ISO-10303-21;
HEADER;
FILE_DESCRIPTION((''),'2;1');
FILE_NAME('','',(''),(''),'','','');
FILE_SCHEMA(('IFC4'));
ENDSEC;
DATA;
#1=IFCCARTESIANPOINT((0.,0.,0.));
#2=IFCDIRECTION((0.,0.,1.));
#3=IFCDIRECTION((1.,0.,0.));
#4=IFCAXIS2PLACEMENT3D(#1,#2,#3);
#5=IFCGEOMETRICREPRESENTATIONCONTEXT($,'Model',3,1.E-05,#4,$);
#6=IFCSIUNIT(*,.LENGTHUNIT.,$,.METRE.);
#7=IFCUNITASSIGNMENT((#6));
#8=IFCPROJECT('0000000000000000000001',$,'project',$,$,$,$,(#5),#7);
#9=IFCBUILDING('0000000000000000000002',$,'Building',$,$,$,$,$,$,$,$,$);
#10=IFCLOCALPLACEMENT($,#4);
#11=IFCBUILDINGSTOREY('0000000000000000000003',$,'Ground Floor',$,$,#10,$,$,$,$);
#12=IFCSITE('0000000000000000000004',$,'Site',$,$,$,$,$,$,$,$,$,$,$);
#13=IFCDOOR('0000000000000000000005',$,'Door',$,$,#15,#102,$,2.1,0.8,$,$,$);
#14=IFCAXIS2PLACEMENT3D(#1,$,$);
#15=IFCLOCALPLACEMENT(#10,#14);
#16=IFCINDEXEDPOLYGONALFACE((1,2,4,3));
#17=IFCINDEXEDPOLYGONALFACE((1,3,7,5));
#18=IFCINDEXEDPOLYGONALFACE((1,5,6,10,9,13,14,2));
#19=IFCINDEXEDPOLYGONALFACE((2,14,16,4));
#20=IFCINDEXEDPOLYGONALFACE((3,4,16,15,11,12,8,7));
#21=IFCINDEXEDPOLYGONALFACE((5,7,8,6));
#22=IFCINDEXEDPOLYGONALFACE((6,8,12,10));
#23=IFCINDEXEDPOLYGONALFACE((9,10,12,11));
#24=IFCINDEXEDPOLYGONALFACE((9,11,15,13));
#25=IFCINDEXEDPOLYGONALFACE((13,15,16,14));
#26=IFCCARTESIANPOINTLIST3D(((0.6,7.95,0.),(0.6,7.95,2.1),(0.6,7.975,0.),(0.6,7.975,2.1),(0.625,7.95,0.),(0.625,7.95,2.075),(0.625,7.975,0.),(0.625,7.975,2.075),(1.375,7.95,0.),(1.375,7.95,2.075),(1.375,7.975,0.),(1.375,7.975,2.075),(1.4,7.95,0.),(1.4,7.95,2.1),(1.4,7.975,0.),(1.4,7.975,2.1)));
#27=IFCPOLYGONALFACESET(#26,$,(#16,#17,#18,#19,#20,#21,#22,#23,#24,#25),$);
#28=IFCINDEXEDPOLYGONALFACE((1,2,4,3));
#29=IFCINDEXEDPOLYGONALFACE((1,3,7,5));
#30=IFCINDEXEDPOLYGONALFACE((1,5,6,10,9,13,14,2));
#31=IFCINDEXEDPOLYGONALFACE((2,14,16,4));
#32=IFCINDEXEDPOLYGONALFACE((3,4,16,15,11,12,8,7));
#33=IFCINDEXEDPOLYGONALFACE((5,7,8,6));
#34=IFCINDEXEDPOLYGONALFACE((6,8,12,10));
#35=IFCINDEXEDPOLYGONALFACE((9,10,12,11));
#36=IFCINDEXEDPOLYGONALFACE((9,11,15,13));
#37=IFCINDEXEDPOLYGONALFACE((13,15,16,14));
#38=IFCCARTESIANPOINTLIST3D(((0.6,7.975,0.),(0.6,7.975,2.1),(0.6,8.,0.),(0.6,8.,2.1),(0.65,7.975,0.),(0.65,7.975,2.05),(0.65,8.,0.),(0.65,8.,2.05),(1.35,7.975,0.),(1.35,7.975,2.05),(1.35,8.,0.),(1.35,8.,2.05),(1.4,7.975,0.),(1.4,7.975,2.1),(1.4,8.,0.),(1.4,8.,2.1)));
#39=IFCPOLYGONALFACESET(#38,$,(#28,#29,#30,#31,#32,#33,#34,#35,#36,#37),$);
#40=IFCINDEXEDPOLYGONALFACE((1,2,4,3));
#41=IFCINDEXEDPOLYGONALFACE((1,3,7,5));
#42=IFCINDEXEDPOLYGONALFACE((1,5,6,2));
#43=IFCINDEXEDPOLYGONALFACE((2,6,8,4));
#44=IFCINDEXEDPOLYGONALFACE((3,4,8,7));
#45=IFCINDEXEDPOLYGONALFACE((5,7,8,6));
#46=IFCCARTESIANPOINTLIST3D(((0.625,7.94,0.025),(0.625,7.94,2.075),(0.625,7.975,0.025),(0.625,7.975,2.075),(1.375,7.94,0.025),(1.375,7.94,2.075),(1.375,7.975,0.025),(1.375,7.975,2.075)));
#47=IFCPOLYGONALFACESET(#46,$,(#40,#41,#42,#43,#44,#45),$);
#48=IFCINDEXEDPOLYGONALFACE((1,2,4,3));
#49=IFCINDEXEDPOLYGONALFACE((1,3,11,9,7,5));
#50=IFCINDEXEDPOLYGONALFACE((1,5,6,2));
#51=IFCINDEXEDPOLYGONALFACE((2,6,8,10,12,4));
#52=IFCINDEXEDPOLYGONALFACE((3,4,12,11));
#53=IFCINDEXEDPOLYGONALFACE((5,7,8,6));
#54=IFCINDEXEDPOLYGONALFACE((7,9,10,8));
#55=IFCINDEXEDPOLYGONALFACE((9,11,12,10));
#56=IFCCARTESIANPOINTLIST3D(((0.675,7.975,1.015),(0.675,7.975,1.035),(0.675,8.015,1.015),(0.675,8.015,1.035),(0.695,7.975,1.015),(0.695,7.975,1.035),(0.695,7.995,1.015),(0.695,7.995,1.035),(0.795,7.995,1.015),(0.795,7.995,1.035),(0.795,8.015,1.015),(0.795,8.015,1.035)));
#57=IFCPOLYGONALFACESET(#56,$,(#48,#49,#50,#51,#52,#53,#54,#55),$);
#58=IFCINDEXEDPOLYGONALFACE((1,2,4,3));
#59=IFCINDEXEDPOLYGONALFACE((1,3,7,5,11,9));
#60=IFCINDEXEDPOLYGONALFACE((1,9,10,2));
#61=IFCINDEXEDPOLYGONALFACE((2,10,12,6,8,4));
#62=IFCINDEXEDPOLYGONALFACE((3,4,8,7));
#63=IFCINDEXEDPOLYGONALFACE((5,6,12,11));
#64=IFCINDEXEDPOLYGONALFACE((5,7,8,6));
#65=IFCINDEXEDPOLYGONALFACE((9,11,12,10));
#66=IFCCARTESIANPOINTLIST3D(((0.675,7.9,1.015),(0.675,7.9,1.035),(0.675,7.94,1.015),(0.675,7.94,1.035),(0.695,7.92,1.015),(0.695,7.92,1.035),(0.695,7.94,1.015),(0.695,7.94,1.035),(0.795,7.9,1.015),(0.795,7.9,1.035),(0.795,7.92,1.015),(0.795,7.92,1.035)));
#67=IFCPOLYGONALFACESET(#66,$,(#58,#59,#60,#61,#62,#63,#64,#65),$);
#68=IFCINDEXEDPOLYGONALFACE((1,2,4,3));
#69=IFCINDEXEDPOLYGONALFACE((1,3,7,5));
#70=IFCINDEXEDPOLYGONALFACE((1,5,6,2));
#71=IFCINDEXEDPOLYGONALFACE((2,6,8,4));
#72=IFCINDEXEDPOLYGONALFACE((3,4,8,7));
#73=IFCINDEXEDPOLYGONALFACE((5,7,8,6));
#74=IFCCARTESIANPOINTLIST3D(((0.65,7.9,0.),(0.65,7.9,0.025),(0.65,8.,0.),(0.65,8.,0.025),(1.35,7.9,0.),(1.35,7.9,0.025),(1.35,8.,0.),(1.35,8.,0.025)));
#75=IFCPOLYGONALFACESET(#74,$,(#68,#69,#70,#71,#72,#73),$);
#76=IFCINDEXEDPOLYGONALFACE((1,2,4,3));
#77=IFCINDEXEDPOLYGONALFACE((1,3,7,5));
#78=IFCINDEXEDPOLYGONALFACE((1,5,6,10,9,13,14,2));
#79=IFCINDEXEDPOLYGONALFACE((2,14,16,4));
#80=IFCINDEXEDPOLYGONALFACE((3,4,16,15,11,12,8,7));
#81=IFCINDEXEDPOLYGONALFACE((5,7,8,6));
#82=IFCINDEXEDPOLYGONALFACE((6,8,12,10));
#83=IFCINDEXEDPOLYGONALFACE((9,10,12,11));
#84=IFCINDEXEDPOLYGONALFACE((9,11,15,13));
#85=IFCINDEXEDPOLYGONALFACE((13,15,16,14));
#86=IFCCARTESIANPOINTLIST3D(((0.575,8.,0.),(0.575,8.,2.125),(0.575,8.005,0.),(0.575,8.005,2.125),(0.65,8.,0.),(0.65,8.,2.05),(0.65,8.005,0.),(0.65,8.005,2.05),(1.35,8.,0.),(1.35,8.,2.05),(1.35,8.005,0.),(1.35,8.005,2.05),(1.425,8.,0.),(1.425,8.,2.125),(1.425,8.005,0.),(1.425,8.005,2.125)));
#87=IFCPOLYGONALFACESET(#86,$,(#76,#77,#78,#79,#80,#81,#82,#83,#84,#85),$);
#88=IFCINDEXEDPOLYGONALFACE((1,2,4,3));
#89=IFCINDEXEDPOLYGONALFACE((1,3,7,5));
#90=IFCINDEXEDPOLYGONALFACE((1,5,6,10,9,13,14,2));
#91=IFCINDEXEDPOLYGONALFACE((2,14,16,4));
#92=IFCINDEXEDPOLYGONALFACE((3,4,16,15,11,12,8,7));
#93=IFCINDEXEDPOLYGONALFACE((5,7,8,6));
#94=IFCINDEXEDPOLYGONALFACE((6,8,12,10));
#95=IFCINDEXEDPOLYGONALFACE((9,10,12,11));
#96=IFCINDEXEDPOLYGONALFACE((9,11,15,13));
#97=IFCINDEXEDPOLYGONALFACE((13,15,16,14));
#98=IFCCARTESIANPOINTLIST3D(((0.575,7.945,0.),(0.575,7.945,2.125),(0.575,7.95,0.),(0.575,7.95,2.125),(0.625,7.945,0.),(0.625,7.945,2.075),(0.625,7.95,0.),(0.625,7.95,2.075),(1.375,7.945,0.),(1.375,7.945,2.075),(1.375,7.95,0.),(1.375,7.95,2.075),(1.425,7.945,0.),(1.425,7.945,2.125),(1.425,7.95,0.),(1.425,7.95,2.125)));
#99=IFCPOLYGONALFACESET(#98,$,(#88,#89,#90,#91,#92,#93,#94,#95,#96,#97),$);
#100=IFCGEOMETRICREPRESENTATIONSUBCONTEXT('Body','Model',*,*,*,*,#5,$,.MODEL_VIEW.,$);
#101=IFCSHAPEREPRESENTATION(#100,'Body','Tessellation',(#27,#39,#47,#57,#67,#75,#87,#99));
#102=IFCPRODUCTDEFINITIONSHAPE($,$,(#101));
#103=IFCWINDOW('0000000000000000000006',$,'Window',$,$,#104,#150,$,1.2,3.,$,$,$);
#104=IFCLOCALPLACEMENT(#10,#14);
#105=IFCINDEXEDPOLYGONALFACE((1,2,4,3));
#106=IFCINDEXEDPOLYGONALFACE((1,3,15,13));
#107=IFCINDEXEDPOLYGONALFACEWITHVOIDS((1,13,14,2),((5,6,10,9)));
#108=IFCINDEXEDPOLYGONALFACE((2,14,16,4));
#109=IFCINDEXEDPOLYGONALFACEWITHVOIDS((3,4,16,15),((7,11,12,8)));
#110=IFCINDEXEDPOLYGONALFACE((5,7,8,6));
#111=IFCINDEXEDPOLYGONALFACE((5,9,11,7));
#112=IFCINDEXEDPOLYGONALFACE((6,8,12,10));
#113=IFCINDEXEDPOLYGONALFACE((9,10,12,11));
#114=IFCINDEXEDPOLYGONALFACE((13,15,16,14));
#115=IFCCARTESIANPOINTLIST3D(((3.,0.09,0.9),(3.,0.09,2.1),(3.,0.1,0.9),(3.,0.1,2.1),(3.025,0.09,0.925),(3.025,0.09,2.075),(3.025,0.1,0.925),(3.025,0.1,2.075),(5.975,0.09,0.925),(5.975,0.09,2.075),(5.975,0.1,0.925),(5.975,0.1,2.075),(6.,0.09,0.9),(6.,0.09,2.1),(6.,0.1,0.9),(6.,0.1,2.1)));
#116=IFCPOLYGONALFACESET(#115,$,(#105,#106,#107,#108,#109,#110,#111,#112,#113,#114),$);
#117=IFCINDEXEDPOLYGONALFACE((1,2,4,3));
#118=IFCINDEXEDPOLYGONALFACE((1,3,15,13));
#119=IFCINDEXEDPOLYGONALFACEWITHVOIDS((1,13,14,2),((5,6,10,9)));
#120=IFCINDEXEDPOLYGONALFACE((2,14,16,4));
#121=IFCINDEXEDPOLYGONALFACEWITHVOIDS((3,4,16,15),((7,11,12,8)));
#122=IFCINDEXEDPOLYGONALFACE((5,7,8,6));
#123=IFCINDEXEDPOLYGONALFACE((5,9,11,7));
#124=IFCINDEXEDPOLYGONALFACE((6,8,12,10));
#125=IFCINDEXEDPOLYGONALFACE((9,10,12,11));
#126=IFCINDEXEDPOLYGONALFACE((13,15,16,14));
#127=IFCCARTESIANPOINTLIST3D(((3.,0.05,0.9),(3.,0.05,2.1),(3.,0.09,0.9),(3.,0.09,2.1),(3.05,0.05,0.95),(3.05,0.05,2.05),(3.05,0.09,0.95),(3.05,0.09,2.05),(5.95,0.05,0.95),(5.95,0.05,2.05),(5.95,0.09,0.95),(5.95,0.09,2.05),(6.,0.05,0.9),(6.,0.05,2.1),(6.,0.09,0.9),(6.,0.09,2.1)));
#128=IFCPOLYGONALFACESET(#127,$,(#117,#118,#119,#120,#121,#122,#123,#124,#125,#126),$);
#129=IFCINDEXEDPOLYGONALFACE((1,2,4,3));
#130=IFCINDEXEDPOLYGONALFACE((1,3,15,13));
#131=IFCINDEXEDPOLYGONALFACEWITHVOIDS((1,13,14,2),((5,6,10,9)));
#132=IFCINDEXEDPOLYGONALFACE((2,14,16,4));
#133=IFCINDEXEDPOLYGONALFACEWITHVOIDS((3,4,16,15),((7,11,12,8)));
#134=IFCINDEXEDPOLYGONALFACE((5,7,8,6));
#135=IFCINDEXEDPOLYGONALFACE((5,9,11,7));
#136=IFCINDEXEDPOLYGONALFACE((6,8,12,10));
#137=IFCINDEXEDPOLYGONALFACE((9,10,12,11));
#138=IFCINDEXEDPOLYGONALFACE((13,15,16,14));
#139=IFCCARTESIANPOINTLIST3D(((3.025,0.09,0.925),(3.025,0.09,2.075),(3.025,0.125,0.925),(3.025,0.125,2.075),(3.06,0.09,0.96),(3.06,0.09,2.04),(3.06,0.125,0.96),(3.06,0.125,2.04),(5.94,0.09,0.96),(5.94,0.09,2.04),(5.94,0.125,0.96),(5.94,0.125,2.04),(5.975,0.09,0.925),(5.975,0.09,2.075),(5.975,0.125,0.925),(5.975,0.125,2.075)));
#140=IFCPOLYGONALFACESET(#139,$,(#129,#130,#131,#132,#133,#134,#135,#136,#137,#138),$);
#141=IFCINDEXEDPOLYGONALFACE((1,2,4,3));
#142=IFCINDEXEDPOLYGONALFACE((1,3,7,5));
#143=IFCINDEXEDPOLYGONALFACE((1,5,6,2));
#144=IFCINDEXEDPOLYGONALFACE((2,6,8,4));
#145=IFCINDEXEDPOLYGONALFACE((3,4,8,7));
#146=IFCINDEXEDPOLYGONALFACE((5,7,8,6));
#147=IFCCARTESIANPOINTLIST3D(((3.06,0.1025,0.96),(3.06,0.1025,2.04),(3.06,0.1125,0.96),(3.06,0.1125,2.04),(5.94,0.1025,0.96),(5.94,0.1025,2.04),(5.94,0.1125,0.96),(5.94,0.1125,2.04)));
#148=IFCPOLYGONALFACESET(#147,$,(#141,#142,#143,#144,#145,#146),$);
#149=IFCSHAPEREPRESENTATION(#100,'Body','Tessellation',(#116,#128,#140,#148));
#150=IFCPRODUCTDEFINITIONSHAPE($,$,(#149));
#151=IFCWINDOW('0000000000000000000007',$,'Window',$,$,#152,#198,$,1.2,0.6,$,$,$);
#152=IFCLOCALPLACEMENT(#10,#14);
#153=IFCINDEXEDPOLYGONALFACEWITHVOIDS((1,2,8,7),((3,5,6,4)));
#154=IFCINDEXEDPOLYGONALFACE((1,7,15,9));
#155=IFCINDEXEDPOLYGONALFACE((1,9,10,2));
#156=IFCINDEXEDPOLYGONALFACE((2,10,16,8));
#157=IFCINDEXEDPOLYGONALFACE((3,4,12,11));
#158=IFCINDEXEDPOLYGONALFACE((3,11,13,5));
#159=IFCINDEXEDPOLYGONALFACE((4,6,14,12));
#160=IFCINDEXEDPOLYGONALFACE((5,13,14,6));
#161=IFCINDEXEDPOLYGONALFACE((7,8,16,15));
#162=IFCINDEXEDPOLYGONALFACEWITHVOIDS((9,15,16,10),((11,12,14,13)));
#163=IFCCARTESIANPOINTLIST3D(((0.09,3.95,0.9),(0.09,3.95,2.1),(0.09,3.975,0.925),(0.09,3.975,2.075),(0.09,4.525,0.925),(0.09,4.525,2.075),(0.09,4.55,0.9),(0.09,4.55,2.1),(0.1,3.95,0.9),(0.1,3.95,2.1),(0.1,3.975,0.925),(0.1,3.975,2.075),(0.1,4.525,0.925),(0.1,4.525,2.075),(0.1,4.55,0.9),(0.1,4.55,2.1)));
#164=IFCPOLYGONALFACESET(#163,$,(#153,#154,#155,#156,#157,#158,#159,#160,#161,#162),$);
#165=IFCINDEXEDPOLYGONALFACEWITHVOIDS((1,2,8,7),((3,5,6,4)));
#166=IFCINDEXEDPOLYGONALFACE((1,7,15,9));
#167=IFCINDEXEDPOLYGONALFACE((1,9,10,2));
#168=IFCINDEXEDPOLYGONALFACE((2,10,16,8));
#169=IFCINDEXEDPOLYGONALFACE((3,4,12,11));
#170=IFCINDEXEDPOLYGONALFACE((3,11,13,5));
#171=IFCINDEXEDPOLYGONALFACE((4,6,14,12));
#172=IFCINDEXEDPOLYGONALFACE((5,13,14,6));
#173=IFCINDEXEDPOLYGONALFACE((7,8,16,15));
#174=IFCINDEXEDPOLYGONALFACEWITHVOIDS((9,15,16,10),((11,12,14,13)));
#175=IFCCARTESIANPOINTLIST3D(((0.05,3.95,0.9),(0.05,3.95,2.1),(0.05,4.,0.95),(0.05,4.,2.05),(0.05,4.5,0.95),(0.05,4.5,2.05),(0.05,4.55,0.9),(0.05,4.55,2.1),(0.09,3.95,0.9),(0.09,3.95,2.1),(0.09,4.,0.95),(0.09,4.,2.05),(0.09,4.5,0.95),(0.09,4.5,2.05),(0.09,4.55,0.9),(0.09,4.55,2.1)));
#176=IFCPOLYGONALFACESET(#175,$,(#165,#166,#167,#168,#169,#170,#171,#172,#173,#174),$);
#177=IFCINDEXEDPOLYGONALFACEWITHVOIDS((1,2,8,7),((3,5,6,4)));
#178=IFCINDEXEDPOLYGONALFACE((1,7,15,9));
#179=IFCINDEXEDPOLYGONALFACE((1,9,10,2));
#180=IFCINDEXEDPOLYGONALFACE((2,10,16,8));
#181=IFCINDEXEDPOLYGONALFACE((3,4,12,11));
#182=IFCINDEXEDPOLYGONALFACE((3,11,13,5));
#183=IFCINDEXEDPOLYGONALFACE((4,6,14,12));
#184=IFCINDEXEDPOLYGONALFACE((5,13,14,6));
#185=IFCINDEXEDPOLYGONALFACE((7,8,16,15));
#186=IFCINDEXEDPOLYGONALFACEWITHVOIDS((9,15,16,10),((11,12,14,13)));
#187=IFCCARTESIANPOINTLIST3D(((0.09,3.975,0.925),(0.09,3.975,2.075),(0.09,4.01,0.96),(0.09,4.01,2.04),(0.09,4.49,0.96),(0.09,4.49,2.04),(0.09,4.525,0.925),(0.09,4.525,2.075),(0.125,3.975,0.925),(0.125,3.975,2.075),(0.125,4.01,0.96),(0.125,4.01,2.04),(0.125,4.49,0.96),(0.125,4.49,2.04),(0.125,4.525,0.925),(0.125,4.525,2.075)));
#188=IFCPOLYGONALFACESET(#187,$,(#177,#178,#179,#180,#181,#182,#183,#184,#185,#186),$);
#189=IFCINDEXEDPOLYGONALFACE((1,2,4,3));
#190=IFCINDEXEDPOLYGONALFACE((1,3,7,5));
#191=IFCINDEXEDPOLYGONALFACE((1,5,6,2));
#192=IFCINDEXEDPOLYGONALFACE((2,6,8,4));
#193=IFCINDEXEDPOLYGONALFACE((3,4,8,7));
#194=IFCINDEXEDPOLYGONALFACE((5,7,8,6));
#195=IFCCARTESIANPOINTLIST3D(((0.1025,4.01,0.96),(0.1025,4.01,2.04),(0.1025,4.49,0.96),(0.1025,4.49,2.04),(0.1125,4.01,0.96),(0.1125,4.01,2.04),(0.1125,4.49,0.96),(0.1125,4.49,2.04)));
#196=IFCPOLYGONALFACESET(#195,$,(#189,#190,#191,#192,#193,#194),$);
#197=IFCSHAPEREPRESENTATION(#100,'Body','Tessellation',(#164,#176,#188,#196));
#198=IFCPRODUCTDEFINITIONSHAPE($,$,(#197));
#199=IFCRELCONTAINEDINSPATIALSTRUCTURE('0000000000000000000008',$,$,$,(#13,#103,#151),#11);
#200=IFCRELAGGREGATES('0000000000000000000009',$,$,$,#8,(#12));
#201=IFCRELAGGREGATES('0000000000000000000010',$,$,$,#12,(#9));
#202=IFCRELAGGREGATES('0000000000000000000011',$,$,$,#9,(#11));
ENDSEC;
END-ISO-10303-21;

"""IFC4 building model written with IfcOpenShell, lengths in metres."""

from ifc_helpers import new_model, si_unit, frame, origin_with_axes, place, context, subcontext, project, spatial, line, indexed_curve, outline, extrude, element, save


model = new_model("IFC4")

# Units and contexts
model_context = context("Model", 3, precision=1e-05, world=origin_with_axes())
body_context = subcontext(model_context, "Body", "Model", "MODEL_VIEW")
ifc_project = project(units=[si_unit("LENGTHUNIT", "METRE")], contexts=[model_context])

# Site, building, storey
site = spatial("IfcSite", under=ifc_project, Name="Site")
building = spatial("IfcBuilding", under=site, Name="Building")
storey_placement = place(None, origin_with_axes())
storey = spatial("IfcBuildingStorey", under=building, at=storey_placement, Name="Ground Floor")

# Door
door_1_placement = place(storey_placement, frame((1.4, 8.0, 0.0), z_axis=(0.0, 0.0, 1.0), x_axis=(-1.0, 0.0, 0.0)))
element("IfcDoor", 1, at=door_1_placement, inside=storey, Name="Door", OverallHeight=2.1, OverallWidth=0.8, context=body_context, shape_type="SweptSolid", body=[
    extrude(outline(indexed_curve([(0.0, 0.0), (0.0, 2.1), (0.8, 2.1), (0.8, 0.0), (0.775, 0.0), (0.775, 2.075), (0.025, 2.075), (0.025, 0.0)], segments=[line(1, 2, 3, 4, 5, 6, 7, 8, 1)])), frame((0.0, 0.025, 0.0), z_axis=(0.0, -1.0, 0.0), x_axis=(1.0, 0.0, 0.0)), (0.0, 0.0, -1.0), 0.025),
    extrude(outline(indexed_curve([(0.0, 0.0), (0.0, 2.1), (0.8, 2.1), (0.8, 0.0), (0.75, 0.0), (0.75, 2.05), (0.05, 2.05), (0.05, 0.0)], segments=[line(1, 2, 3, 4, 5, 6, 7, 8, 1)])), frame((0.0, 0.0, 0.0), z_axis=(0.0, -1.0, 0.0), x_axis=(1.0, 0.0, 0.0)), (0.0, 0.0, -1.0), 0.025),
    extrude(outline(indexed_curve([(0.0, 0.0), (0.75, 0.0), (0.75, 0.035), (0.0, 0.035)], segments=[line(1, 2, 3, 4, 1)])), frame((0.025, 0.025, 0.025), z_axis=(0.0, 0.0, 1.0), x_axis=(1.0, 0.0, 0.0)), (0.0, 0.0, 1.0), 2.05),
    extrude(outline(indexed_curve([(0.0, 0.0), (0.0, -0.04), (-0.12, -0.04), (-0.12, -0.02), (-0.02, -0.02), (-0.02, 0.0)], segments=[line(1, 2, 3, 4, 5, 6, 1)])), frame((0.725, 0.025, 1.015), z_axis=(0.0, 0.0, 1.0), x_axis=(1.0, 0.0, 0.0)), (0.0, 0.0, 1.0), 0.02),
    extrude(outline(indexed_curve([(0.0, 0.0), (0.0, 0.04), (-0.12, 0.04), (-0.12, 0.02), (-0.02, 0.02), (-0.02, 0.0)], segments=[line(1, 2, 3, 4, 5, 6, 1)])), frame((0.725, 0.06, 1.015), z_axis=(0.0, 0.0, 1.0), x_axis=(1.0, 0.0, 0.0)), (0.0, 0.0, 1.0), 0.02),
    extrude(outline(indexed_curve([(0.0, 0.0), (0.7, 0.0), (0.7, 0.1), (0.0, 0.1)], segments=[line(1, 2, 3, 4, 1)])), frame((0.05, 0.0, 0.0), z_axis=(0.0, 0.0, 1.0), x_axis=(1.0, 0.0, 0.0)), (0.0, 0.0, 1.0), 0.025),
    extrude(outline(indexed_curve([(0.0, 0.0), (0.0, 2.125), (0.85, 2.125), (0.85, 0.0), (0.775, 0.0), (0.775, 2.05), (0.075, 2.05), (0.075, 0.0)], segments=[line(1, 2, 3, 4, 5, 6, 7, 8, 1)])), frame((-0.025, -0.005, 0.0), z_axis=(0.0, -1.0, 0.0), x_axis=(1.0, 0.0, 0.0)), (0.0, 0.0, -1.0), 0.005),
    extrude(outline(indexed_curve([(0.0, 0.0), (0.0, 2.125), (0.85, 2.125), (0.85, 0.0), (0.8, 0.0), (0.8, 2.075), (0.05, 2.075), (0.05, 0.0)], segments=[line(1, 2, 3, 4, 5, 6, 7, 8, 1)])), frame((-0.025, 0.05, 0.0), z_axis=(0.0, -1.0, 0.0), x_axis=(1.0, 0.0, 0.0)), (0.0, 0.0, -1.0), 0.005),
])

# Windows
window_1_placement = place(storey_placement, frame((3.0, 0.0, 0.9), z_axis=(0.0, 0.0, 1.0), x_axis=(1.0, 0.0, 0.0)))
element("IfcWindow", 2, at=window_1_placement, inside=storey, Name="Window", OverallHeight=1.2, OverallWidth=3.0, context=body_context, shape_type="SweptSolid", body=[
    extrude(outline(indexed_curve([(0.0, 0.0), (3.0, 0.0), (3.0, 1.2), (0.0, 1.2)], segments=[line(1, 2, 3, 4, 1)]), holes=[indexed_curve([(0.025, 0.025), (2.975, 0.025), (2.975, 1.175), (0.025, 1.175)], segments=[line(1, 2, 3, 4, 1)])]), frame((0.0, 0.09, 0.0), z_axis=(0.0, -1.0, 0.0), x_axis=(1.0, 0.0, 0.0)), (0.0, 0.0, -1.0), 0.01),
    extrude(outline(indexed_curve([(0.0, 0.0), (3.0, 0.0), (3.0, 1.2), (0.0, 1.2)], segments=[line(1, 2, 3, 4, 1)]), holes=[indexed_curve([(0.05, 0.05), (2.95, 0.05), (2.95, 1.15), (0.05, 1.15)], segments=[line(1, 2, 3, 4, 1)])]), frame((0.0, 0.05, 0.0), z_axis=(0.0, -1.0, 0.0), x_axis=(1.0, 0.0, 0.0)), (0.0, 0.0, -1.0), 0.04),
    extrude(outline(indexed_curve([(0.0, 0.0), (2.95, 0.0), (2.95, 1.15), (0.0, 1.15)], segments=[line(1, 2, 3, 4, 1)]), holes=[indexed_curve([(0.035, 0.035), (2.915, 0.035), (2.915, 1.115), (0.035, 1.115)], segments=[line(1, 2, 3, 4, 1)])]), frame((0.025, 0.09, 0.025), z_axis=(0.0, -1.0, 0.0), x_axis=(1.0, 0.0, 0.0)), (0.0, 0.0, -1.0), 0.035),
    extrude(outline(indexed_curve([(0.035, 0.035), (2.915, 0.035), (2.915, 1.115), (0.035, 1.115)], segments=[line(1, 2, 3, 4, 1)])), frame((0.025, 0.1025, 0.025), z_axis=(0.0, -1.0, 0.0), x_axis=(1.0, 0.0, 0.0)), (0.0, 0.0, -1.0), 0.01),
])
window_2_placement = place(storey_placement, frame((0.0, 4.55, 0.9), z_axis=(0.0, 0.0, 1.0), x_axis=(0.0, -1.0, 0.0)))
element("IfcWindow", 3, at=window_2_placement, inside=storey, Name="Window", OverallHeight=1.2, OverallWidth=0.6, context=body_context, shape_type="SweptSolid", body=[
    extrude(outline(indexed_curve([(0.0, 0.0), (0.6, 0.0), (0.6, 1.2), (0.0, 1.2)], segments=[line(1, 2, 3, 4, 1)]), holes=[indexed_curve([(0.025, 0.025), (0.575, 0.025), (0.575, 1.175), (0.025, 1.175)], segments=[line(1, 2, 3, 4, 1)])]), frame((0.0, 0.09, 0.0), z_axis=(0.0, -1.0, 0.0), x_axis=(1.0, 0.0, 0.0)), (0.0, 0.0, -1.0), 0.01),
    extrude(outline(indexed_curve([(0.0, 0.0), (0.6, 0.0), (0.6, 1.2), (0.0, 1.2)], segments=[line(1, 2, 3, 4, 1)]), holes=[indexed_curve([(0.05, 0.05), (0.55, 0.05), (0.55, 1.15), (0.05, 1.15)], segments=[line(1, 2, 3, 4, 1)])]), frame((0.0, 0.05, 0.0), z_axis=(0.0, -1.0, 0.0), x_axis=(1.0, 0.0, 0.0)), (0.0, 0.0, -1.0), 0.04),
    extrude(outline(indexed_curve([(0.0, 0.0), (0.55, 0.0), (0.55, 1.15), (0.0, 1.15)], segments=[line(1, 2, 3, 4, 1)]), holes=[indexed_curve([(0.035, 0.035), (0.515, 0.035), (0.515, 1.115), (0.035, 1.115)], segments=[line(1, 2, 3, 4, 1)])]), frame((0.025, 0.09, 0.025), z_axis=(0.0, -1.0, 0.0), x_axis=(1.0, 0.0, 0.0)), (0.0, 0.0, -1.0), 0.035),
    extrude(outline(indexed_curve([(0.035, 0.035), (0.515, 0.035), (0.515, 1.115), (0.035, 1.115)], segments=[line(1, 2, 3, 4, 1)])), frame((0.025, 0.1025, 0.025), z_axis=(0.0, -1.0, 0.0), x_axis=(1.0, 0.0, 0.0)), (0.0, 0.0, -1.0), 0.01),
])

save(model, "model.ifc")
